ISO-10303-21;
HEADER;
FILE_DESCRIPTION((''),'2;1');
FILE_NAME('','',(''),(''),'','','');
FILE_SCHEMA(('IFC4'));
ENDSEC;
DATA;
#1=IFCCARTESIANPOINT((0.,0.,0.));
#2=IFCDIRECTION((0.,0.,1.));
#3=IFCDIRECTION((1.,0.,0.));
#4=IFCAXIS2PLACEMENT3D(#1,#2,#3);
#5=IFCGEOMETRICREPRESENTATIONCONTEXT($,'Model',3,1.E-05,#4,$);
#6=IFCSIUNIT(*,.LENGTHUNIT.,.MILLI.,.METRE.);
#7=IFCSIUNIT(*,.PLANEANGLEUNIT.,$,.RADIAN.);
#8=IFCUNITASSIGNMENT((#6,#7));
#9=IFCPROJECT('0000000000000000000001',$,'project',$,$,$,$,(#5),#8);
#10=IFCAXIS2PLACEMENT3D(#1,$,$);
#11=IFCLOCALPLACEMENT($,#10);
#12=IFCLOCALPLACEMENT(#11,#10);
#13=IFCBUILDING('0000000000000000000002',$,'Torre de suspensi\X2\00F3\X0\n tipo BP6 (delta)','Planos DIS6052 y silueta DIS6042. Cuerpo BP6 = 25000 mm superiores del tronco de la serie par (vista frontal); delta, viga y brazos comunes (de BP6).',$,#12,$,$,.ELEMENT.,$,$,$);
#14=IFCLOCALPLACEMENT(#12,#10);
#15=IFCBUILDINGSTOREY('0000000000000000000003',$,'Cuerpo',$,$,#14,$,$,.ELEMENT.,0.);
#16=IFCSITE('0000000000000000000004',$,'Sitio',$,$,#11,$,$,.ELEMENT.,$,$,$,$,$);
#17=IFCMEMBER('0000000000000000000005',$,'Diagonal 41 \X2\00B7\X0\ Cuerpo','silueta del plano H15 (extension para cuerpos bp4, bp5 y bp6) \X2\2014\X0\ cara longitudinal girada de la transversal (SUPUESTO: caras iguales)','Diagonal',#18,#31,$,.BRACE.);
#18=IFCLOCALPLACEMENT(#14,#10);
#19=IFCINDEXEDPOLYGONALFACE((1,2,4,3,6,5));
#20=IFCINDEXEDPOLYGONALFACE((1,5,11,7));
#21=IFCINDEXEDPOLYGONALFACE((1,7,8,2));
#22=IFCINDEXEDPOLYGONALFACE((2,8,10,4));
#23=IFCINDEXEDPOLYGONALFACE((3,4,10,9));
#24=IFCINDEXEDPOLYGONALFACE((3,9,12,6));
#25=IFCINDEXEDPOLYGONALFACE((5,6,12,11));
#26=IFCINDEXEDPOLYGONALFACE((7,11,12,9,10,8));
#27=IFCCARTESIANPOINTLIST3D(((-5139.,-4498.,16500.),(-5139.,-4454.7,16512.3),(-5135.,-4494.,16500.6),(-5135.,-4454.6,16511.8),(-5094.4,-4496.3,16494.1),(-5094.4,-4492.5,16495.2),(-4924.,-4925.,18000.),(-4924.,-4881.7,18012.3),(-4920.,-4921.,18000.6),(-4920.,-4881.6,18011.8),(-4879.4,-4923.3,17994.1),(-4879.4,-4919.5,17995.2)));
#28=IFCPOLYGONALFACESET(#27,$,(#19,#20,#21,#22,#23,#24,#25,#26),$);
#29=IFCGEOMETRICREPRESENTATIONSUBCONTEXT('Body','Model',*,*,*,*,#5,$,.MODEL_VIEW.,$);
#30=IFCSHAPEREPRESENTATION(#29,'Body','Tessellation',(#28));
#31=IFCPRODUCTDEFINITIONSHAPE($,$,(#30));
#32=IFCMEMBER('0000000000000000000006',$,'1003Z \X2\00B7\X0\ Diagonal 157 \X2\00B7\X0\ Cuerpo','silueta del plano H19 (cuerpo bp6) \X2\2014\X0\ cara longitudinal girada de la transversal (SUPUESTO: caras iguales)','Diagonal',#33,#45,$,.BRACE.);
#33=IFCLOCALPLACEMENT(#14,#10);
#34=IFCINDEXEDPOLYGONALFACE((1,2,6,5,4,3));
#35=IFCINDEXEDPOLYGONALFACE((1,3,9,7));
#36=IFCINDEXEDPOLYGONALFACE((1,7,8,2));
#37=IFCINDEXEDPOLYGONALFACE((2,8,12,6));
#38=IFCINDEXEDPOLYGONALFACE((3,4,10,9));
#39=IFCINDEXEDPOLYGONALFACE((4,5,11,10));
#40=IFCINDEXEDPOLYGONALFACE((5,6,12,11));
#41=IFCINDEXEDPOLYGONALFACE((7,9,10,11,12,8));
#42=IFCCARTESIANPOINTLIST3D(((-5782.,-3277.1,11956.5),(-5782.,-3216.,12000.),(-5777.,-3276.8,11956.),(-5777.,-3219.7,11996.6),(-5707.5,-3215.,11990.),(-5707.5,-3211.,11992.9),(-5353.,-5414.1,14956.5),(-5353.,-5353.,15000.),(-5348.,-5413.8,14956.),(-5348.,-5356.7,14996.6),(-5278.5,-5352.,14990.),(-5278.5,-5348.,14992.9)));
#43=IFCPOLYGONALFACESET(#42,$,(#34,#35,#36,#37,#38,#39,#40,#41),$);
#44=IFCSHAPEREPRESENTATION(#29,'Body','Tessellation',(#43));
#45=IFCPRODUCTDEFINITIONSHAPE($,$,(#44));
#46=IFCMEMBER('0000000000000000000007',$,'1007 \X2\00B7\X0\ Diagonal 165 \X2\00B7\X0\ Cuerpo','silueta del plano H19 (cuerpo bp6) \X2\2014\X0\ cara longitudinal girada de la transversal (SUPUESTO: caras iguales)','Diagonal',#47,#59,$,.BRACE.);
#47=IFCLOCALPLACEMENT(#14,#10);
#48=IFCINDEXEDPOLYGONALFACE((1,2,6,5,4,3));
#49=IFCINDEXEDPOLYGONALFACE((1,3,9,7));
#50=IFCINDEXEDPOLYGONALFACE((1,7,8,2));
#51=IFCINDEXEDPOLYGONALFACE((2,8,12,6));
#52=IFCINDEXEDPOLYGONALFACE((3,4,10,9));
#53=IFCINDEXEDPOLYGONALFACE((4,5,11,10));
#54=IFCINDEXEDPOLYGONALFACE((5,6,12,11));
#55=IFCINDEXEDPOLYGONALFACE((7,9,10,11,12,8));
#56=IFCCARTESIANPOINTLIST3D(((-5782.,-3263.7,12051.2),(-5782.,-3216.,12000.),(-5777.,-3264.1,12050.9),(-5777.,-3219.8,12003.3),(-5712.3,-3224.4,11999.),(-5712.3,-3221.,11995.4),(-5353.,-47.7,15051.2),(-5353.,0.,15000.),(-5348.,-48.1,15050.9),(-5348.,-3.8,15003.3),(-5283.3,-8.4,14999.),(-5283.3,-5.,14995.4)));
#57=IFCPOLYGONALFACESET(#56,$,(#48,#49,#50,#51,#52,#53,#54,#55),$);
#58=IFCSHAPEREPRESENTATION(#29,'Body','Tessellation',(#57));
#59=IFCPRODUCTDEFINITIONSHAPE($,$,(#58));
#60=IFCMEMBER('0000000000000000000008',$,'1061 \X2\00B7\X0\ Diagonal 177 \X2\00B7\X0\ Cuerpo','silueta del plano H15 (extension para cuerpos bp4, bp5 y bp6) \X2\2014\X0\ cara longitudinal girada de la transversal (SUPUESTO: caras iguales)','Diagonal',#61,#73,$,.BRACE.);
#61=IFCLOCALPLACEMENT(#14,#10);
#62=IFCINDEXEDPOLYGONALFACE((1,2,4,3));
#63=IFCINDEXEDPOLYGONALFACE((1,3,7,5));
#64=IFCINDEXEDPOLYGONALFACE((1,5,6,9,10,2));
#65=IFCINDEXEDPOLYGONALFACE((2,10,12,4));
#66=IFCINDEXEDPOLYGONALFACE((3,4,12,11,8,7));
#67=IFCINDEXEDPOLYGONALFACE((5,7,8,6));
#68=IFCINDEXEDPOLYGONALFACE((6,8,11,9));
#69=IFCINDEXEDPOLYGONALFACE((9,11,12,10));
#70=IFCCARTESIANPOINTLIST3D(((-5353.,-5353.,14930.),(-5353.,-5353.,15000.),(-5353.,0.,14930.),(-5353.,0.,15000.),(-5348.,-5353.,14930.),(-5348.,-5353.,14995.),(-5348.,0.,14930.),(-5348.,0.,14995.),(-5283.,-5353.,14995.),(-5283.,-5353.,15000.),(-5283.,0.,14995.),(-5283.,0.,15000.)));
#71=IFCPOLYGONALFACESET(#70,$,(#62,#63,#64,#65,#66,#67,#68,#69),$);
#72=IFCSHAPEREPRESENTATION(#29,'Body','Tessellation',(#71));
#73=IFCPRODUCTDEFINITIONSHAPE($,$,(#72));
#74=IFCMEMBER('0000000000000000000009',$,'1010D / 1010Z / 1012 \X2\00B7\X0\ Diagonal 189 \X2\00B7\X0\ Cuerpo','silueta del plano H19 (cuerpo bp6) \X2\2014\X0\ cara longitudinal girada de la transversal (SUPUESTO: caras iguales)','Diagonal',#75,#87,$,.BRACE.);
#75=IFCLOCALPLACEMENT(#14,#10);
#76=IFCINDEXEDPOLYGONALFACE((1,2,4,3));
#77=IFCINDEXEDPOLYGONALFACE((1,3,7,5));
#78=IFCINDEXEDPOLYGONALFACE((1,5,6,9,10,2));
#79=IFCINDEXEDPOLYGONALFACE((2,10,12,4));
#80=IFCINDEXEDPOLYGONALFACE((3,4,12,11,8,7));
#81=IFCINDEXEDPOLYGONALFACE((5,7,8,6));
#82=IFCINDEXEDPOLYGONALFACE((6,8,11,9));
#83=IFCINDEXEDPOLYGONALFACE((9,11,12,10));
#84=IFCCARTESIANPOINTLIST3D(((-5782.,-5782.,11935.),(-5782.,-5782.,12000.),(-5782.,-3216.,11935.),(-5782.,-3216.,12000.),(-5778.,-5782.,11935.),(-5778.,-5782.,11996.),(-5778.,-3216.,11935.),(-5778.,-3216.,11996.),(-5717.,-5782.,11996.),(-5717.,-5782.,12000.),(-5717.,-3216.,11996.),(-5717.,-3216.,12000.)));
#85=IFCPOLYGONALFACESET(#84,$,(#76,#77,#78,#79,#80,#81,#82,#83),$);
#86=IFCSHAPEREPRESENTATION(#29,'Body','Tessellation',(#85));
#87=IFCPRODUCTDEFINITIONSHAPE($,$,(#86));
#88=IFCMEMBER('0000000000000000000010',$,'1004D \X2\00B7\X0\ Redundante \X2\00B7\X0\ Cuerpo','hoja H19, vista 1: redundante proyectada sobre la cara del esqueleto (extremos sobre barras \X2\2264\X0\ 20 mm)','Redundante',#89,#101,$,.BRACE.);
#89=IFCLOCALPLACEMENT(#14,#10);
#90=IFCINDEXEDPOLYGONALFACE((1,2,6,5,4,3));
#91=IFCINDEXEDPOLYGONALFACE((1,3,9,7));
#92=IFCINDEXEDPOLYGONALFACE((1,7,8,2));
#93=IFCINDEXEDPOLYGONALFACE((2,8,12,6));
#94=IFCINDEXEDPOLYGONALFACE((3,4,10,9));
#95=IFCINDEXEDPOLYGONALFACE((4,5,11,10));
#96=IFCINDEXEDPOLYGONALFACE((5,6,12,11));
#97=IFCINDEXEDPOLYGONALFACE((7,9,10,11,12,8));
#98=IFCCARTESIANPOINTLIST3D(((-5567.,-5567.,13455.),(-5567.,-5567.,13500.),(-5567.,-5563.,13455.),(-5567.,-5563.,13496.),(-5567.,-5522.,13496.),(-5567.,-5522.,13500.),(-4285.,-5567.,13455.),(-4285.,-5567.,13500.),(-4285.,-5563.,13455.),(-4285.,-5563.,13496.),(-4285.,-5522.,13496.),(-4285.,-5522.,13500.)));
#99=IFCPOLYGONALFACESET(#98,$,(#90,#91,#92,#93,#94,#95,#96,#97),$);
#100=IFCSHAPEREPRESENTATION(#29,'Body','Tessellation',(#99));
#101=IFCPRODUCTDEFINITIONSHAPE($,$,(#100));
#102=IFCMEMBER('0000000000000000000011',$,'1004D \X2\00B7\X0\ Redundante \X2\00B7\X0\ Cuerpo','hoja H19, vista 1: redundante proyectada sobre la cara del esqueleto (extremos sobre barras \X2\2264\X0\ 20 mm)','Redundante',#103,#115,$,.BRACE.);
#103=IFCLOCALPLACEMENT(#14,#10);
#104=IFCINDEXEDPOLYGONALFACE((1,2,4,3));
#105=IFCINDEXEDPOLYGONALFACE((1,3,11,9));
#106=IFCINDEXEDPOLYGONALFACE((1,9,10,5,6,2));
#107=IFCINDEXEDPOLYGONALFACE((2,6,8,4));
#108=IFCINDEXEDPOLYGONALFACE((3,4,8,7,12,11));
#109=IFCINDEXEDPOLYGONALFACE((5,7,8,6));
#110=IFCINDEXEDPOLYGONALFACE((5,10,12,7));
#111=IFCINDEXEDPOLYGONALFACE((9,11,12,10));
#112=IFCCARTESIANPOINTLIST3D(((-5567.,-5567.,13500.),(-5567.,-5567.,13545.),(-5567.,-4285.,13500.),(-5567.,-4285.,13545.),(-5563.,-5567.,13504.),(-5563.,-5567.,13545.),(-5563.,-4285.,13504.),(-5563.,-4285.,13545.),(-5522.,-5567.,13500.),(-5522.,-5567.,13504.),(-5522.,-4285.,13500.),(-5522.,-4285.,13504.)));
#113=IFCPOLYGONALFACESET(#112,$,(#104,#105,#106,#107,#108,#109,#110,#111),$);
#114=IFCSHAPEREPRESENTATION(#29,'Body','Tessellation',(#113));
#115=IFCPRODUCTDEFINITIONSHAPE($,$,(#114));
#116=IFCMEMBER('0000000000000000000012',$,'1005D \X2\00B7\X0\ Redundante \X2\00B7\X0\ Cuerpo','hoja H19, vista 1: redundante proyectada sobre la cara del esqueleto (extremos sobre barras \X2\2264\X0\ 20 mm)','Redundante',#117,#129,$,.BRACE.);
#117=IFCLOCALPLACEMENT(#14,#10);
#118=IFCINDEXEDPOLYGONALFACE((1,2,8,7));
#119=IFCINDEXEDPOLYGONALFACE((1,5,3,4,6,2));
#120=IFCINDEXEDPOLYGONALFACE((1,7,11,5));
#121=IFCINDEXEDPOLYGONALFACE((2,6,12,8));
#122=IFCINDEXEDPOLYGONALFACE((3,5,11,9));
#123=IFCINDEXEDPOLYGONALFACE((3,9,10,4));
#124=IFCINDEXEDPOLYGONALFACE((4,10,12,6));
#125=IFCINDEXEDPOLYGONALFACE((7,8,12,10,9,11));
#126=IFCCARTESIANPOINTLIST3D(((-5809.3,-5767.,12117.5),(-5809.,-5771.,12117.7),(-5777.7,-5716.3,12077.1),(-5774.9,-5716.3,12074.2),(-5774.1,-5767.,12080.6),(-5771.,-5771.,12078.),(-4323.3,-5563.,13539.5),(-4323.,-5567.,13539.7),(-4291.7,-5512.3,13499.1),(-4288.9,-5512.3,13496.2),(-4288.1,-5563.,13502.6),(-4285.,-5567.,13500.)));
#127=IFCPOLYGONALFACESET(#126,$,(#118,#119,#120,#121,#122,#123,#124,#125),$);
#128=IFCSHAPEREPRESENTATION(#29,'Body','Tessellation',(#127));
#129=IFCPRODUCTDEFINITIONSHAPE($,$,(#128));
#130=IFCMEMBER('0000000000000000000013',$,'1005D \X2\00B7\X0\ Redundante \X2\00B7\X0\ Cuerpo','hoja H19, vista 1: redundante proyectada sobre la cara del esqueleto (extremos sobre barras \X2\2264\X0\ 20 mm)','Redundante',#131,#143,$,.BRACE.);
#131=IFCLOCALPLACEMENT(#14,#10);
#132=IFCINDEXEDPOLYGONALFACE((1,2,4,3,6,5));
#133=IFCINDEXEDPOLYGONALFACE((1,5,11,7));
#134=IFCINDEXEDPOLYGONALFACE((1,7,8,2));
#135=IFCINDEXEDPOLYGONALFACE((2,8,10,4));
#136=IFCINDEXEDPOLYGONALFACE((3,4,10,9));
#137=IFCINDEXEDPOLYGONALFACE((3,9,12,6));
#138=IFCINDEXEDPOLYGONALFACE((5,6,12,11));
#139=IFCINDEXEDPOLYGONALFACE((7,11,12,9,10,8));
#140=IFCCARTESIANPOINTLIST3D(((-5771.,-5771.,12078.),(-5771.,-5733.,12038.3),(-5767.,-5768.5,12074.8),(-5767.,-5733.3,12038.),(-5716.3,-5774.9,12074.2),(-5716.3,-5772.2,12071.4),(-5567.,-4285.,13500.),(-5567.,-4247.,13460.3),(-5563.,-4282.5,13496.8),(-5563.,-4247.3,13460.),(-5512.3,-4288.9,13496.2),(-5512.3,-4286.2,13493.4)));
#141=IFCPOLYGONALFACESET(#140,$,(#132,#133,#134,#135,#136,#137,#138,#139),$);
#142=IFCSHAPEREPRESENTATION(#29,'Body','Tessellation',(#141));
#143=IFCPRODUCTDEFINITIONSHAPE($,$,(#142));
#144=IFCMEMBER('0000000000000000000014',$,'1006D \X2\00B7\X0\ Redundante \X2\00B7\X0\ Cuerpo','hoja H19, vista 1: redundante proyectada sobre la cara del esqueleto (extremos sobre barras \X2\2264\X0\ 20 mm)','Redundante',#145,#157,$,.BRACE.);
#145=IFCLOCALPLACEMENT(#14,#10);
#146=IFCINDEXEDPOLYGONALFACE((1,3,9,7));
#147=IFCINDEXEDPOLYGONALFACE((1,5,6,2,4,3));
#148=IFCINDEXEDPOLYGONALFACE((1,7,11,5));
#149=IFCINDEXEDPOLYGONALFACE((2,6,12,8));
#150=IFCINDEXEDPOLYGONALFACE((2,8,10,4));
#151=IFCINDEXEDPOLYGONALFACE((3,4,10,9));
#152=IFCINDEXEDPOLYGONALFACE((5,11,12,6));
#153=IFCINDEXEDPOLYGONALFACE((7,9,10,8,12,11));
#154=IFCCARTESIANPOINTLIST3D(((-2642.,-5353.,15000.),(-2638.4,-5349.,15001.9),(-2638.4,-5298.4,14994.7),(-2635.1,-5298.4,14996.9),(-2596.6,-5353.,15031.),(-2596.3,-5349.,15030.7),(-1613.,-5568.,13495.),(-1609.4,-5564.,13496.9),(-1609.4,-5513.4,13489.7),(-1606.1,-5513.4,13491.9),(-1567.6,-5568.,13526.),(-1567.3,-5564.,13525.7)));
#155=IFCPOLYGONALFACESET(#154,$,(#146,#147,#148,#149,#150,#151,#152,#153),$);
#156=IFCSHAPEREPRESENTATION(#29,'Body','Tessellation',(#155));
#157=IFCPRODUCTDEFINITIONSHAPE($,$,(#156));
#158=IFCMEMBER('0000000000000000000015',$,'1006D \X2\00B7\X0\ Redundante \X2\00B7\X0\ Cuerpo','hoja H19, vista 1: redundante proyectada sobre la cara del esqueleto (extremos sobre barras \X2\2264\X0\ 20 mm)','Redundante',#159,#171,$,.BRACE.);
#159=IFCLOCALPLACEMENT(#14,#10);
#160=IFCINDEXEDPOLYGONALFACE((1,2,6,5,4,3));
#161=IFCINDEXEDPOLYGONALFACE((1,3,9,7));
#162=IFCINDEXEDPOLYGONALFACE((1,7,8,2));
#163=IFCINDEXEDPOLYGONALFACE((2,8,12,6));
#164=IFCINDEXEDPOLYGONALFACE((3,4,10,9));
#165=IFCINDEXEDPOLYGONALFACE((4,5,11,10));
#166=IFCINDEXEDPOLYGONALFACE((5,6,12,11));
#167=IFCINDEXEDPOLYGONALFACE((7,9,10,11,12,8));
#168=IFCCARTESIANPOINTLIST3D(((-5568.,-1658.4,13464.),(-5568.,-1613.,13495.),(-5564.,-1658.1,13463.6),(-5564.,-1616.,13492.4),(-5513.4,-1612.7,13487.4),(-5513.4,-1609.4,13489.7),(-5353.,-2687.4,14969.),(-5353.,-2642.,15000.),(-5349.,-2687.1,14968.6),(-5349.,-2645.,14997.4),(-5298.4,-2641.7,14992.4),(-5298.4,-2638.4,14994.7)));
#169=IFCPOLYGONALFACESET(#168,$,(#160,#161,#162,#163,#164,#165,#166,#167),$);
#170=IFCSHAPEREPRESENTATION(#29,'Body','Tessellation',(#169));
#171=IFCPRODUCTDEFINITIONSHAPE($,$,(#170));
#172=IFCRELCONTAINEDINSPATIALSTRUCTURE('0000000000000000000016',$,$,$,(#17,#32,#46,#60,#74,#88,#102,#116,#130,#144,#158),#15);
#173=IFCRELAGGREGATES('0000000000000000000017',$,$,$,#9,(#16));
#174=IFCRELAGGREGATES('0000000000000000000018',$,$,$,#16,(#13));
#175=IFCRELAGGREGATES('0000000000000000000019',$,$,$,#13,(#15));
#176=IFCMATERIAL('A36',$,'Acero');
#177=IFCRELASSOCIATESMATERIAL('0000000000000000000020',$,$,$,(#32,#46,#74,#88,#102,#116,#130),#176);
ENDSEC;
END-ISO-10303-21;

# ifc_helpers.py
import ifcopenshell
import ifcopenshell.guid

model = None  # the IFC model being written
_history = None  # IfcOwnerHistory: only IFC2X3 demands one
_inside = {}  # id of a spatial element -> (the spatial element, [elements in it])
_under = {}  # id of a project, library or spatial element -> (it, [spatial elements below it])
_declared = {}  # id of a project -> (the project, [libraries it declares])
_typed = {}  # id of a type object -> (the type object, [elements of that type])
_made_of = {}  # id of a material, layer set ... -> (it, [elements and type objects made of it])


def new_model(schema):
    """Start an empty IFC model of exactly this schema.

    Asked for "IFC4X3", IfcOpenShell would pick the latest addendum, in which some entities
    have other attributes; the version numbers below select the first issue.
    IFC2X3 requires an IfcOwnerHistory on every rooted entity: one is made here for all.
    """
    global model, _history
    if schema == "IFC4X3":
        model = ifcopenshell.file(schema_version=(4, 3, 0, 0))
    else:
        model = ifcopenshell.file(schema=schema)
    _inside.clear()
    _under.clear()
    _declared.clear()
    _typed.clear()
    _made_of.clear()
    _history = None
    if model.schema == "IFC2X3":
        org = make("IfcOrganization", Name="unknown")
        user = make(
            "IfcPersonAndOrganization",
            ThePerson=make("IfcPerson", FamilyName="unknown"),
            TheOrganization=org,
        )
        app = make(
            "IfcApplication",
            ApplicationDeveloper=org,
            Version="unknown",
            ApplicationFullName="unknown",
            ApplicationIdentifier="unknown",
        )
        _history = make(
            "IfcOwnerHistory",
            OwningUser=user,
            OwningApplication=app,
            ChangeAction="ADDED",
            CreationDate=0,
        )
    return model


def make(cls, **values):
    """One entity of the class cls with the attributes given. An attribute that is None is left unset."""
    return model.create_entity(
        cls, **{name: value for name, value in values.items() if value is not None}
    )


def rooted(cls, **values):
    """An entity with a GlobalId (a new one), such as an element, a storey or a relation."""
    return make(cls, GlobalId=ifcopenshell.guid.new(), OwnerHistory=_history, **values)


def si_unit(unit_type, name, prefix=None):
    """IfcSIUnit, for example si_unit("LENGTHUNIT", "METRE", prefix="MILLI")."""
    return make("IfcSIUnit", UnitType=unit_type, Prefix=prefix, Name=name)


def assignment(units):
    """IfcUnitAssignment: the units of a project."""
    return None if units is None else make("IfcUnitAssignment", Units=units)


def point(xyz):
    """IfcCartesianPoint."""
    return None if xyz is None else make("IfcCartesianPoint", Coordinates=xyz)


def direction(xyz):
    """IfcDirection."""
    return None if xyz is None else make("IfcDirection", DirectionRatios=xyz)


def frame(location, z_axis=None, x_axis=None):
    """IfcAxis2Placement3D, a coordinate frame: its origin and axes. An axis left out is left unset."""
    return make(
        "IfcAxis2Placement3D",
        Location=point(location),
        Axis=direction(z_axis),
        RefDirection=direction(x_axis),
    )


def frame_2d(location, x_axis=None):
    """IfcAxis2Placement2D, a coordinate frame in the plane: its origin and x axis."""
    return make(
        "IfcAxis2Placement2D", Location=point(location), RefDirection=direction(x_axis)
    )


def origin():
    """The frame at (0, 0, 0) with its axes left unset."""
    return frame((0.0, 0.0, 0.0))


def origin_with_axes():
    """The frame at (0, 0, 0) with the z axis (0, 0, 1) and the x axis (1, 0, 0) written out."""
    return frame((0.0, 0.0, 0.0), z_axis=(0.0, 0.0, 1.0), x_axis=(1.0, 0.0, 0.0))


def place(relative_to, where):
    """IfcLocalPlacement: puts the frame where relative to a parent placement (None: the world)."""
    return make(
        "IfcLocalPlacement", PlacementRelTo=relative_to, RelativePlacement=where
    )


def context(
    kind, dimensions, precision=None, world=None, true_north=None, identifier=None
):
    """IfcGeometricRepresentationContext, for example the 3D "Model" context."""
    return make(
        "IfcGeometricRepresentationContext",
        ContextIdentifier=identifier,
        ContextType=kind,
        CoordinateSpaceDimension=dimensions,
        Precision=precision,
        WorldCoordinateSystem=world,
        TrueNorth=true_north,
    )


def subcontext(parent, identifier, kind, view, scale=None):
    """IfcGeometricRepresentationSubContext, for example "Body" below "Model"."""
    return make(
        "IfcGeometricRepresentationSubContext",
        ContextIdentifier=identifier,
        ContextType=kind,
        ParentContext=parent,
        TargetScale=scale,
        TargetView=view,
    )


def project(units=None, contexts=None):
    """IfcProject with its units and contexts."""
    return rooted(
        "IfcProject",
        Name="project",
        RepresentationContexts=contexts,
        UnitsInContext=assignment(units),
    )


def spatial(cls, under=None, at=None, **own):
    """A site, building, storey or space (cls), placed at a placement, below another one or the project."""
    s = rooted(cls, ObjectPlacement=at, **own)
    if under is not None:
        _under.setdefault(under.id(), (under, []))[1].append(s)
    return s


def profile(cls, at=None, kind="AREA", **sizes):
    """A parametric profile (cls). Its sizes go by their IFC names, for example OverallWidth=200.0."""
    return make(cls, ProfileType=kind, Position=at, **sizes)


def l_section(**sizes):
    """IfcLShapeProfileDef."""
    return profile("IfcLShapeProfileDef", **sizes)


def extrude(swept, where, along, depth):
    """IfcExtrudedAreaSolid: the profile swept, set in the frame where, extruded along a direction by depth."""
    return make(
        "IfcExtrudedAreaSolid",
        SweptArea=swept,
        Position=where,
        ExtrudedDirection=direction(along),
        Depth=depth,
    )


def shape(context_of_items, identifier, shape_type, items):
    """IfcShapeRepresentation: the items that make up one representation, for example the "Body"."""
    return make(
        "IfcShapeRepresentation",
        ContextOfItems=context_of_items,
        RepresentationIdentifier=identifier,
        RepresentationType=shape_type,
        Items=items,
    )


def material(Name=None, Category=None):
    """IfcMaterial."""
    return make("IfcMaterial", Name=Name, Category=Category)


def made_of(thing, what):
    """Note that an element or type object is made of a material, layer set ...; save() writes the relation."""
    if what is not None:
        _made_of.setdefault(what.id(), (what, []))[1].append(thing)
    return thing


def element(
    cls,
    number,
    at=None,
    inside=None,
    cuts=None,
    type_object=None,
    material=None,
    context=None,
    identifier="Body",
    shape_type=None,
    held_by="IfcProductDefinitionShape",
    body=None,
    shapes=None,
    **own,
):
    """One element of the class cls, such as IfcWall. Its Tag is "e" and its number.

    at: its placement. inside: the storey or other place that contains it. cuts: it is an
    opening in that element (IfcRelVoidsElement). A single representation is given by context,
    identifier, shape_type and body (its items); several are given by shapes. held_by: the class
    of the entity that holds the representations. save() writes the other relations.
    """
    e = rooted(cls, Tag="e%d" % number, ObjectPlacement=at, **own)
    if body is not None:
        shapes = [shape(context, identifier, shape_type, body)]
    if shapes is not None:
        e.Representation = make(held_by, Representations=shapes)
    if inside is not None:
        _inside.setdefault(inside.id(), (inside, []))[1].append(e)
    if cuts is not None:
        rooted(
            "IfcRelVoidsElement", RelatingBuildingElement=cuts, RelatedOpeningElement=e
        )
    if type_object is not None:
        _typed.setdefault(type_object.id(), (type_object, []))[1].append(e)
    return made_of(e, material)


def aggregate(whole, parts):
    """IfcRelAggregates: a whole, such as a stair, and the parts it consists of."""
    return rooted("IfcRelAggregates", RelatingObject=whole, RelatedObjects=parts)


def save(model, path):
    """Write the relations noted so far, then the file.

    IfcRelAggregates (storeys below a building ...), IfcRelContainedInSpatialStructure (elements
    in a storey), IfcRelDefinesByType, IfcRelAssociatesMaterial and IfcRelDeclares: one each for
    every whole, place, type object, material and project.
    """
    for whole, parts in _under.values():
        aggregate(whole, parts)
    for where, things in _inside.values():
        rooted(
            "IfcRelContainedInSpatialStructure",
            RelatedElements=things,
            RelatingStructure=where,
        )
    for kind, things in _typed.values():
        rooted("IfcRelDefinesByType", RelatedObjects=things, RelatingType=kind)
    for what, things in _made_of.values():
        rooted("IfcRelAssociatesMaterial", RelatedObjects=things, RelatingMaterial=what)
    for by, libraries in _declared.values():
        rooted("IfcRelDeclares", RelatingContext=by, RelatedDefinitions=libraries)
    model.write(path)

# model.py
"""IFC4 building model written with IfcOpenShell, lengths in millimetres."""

from ifc_helpers import new_model, si_unit, frame, frame_2d, origin, origin_with_axes, place, context, subcontext, project, spatial, l_section, extrude, material, element, save


model = new_model("IFC4")

# Units and contexts
model_context = context("Model", 3, precision=1e-05, world=origin_with_axes())
body_context = subcontext(model_context, "Body", "Model", "MODEL_VIEW")
ifc_project = project(units=[si_unit("LENGTHUNIT", "METRE", prefix="MILLI"), si_unit("PLANEANGLEUNIT", "RADIAN")], contexts=[model_context])

# Site, building, storey
site_placement = place(None, origin())
site = spatial("IfcSite", under=ifc_project, at=site_placement, Name="Sitio", CompositionType="ELEMENT")
building_placement = place(site_placement, origin())
building = spatial("IfcBuilding", under=site, at=building_placement, Name="Torre de suspensión tipo BP6 (delta)", Description="Planos DIS6052 y silueta DIS6042. Cuerpo BP6 = 25000 mm superiores del tronco de la serie par (vista frontal); delta, viga y brazos comunes (de BP6).", CompositionType="ELEMENT")
storey_placement = place(building_placement, origin())
storey = spatial("IfcBuildingStorey", under=building, at=storey_placement, Name="Cuerpo", CompositionType="ELEMENT", Elevation=0.0)

# Members
ifc_material_1 = material(Name="A36", Category="Acero")
member_1_placement = place(storey_placement, frame((-5139.0, -4498.0, 16500.0), z_axis=(0.136565, -0.271224, 0.952779), x_axis=(0.990631, 0.03739, -0.131347)))
element("IfcMember", 1, at=member_1_placement, inside=storey, Name="Diagonal 41 · Cuerpo", Description="silueta del plano H15 (extension para cuerpos bp4, bp5 y bp6) — cara longitudinal girada de la transversal (SUPUESTO: caras iguales)", ObjectType="Diagonal", PredefinedType="BRACE", context=body_context, shape_type="SweptSolid", body=[
    extrude(l_section(Depth=45.0, Width=45.0, Thickness=4.0, at=frame_2d((22.5, 22.5))), None, (0.0, 0.0, 1.0), 1574.3),
])
member_2_placement = place(storey_placement, frame((-5353.0, -5353.0, 15000.0), z_axis=(-0.115689, 0.576289, -0.809016), x_axis=(0.993285, 0.067121, -0.094227)))
element("IfcMember", 2, at=member_2_placement, inside=storey, material=ifc_material_1, Name="1003Z · Diagonal 157 · Cuerpo", Description="silueta del plano H19 (cuerpo bp6) — cara longitudinal girada de la transversal (SUPUESTO: caras iguales)", ObjectType="Diagonal", PredefinedType="BRACE", context=body_context, shape_type="SweptSolid", body=[
    extrude(l_section(Depth=75.0, Width=75.0, Thickness=5.0, at=frame_2d((37.5, 37.5))), None, (0.0, 0.0, 1.0), 3708.2),
])
member_3_placement = place(storey_placement, frame((-5353.0, 0.0, 15000.0), z_axis=(-0.097083, -0.727783, -0.678902), x_axis=(0.995276, -0.070991, -0.066223)))
element("IfcMember", 3, at=member_3_placement, inside=storey, material=ifc_material_1, Name="1007 · Diagonal 165 · Cuerpo", Description="silueta del plano H19 (cuerpo bp6) — cara longitudinal girada de la transversal (SUPUESTO: caras iguales)", ObjectType="Diagonal", PredefinedType="BRACE", context=body_context, shape_type="SweptSolid", body=[
    extrude(l_section(Depth=70.0, Width=70.0, Thickness=5.0, at=frame_2d((35.0, 35.0))), None, (0.0, 0.0, 1.0), 4418.9),
])
member_4_placement = place(storey_placement, frame((-5353.0, -5353.0, 15000.0), z_axis=(0.0, 1.0, 0.0), x_axis=(1.0, 0.0, 0.0)))
element("IfcMember", 4, at=member_4_placement, inside=storey, Name="1061 · Diagonal 177 · Cuerpo", Description="silueta del plano H15 (extension para cuerpos bp4, bp5 y bp6) — cara longitudinal girada de la transversal (SUPUESTO: caras iguales)", ObjectType="Diagonal", PredefinedType="BRACE", context=body_context, shape_type="SweptSolid", body=[
    extrude(l_section(Depth=70.0, Width=70.0, Thickness=5.0, at=frame_2d((35.0, 35.0))), None, (0.0, 0.0, 1.0), 5353.0),
])
member_5_placement = place(storey_placement, frame((-5782.0, -5782.0, 12000.0), z_axis=(0.0, 1.0, 0.0), x_axis=(1.0, 0.0, 0.0)))
element("IfcMember", 5, at=member_5_placement, inside=storey, material=ifc_material_1, Name="1010D / 1010Z / 1012 · Diagonal 189 · Cuerpo", Description="silueta del plano H19 (cuerpo bp6) — cara longitudinal girada de la transversal (SUPUESTO: caras iguales)", ObjectType="Diagonal", PredefinedType="BRACE", context=body_context, shape_type="SweptSolid", body=[
    extrude(l_section(Depth=65.0, Width=65.0, Thickness=4.0, at=frame_2d((32.5, 32.5))), None, (0.0, 0.0, 1.0), 2566.0),
])
for number, where, z_axis, x_axis, name in (
    (6, (-4285.0, -5567.0, 13500.0), (-1.0, 0.0, 0.0), (0.0, 1.0, 0.0), "1004D · Redundante · Cuerpo"),
    (7, (-5567.0, -4285.0, 13500.0), (0.0, -1.0, 0.0), (1.0, 0.0, 0.0), "1004D · Redundante · Cuerpo"),
):
    element("IfcMember", number, at=place(storey_placement, frame(where, z_axis=z_axis, x_axis=x_axis)), inside=storey, material=ifc_material_1, Name=name, Description="hoja H19, vista 1: redundante proyectada sobre la cara del esqueleto (extremos sobre barras ≤ 20 mm)", ObjectType="Redundante", PredefinedType="BRACE", context=body_context, shape_type="SweptSolid", body=[
        extrude(l_section(Depth=45.0, Width=45.0, Thickness=4.0, at=frame_2d((22.5, 22.5))), None, (0.0, 0.0, 1.0), 1282.0),
    ])
for number, where, z_axis, x_axis, name in (
    (8, (-5771.0, -5771.0, 12078.0), (0.718966, 0.098701, 0.688001), (-0.071311, 0.995117, -0.068239), "1005D · Redundante · Cuerpo"),
    (9, (-5771.0, -5771.0, 12078.0), (0.098701, 0.718966, 0.688001), (0.995117, -0.071311, -0.068239), "1005D · Redundante · Cuerpo"),
):
    element("IfcMember", number, at=place(storey_placement, frame(where, z_axis=z_axis, x_axis=x_axis)), inside=storey, material=ifc_material_1, Name=name, Description="hoja H19, vista 1: redundante proyectada sobre la cara del esqueleto (extremos sobre barras ≤ 20 mm)", ObjectType="Redundante", PredefinedType="BRACE", context=body_context, shape_type="SweptSolid", body=[
        extrude(l_section(Depth=55.0, Width=55.0, Thickness=4.0, at=frame_2d((27.5, 27.5))), None, (0.0, 0.0, 1.0), 2066.9),
    ])
for number, where, z_axis, x_axis, name in (
    (10, (-2642.0, -5353.0, 15000.0), (0.560524, -0.117116, -0.819815), (0.066101, 0.993118, -0.096679), "1006D · Redundante · Cuerpo"),
    (11, (-5353.0, -2642.0, 15000.0), (-0.117116, 0.560524, -0.819815), (0.993118, 0.066101, -0.096679), "1006D · Redundante · Cuerpo"),
):
    element("IfcMember", number, at=place(storey_placement, frame(where, z_axis=z_axis, x_axis=x_axis)), inside=storey, Name=name, Description="hoja H19, vista 1: redundante proyectada sobre la cara del esqueleto (extremos sobre barras ≤ 20 mm)", ObjectType="Redundante", PredefinedType="BRACE", context=body_context, shape_type="SweptSolid", body=[
        extrude(l_section(Depth=55.0, Width=55.0, Thickness=4.0, at=frame_2d((27.5, 27.5))), None, (0.0, 0.0, 1.0), 1835.8),
    ])

save(model, "model.ifc")
